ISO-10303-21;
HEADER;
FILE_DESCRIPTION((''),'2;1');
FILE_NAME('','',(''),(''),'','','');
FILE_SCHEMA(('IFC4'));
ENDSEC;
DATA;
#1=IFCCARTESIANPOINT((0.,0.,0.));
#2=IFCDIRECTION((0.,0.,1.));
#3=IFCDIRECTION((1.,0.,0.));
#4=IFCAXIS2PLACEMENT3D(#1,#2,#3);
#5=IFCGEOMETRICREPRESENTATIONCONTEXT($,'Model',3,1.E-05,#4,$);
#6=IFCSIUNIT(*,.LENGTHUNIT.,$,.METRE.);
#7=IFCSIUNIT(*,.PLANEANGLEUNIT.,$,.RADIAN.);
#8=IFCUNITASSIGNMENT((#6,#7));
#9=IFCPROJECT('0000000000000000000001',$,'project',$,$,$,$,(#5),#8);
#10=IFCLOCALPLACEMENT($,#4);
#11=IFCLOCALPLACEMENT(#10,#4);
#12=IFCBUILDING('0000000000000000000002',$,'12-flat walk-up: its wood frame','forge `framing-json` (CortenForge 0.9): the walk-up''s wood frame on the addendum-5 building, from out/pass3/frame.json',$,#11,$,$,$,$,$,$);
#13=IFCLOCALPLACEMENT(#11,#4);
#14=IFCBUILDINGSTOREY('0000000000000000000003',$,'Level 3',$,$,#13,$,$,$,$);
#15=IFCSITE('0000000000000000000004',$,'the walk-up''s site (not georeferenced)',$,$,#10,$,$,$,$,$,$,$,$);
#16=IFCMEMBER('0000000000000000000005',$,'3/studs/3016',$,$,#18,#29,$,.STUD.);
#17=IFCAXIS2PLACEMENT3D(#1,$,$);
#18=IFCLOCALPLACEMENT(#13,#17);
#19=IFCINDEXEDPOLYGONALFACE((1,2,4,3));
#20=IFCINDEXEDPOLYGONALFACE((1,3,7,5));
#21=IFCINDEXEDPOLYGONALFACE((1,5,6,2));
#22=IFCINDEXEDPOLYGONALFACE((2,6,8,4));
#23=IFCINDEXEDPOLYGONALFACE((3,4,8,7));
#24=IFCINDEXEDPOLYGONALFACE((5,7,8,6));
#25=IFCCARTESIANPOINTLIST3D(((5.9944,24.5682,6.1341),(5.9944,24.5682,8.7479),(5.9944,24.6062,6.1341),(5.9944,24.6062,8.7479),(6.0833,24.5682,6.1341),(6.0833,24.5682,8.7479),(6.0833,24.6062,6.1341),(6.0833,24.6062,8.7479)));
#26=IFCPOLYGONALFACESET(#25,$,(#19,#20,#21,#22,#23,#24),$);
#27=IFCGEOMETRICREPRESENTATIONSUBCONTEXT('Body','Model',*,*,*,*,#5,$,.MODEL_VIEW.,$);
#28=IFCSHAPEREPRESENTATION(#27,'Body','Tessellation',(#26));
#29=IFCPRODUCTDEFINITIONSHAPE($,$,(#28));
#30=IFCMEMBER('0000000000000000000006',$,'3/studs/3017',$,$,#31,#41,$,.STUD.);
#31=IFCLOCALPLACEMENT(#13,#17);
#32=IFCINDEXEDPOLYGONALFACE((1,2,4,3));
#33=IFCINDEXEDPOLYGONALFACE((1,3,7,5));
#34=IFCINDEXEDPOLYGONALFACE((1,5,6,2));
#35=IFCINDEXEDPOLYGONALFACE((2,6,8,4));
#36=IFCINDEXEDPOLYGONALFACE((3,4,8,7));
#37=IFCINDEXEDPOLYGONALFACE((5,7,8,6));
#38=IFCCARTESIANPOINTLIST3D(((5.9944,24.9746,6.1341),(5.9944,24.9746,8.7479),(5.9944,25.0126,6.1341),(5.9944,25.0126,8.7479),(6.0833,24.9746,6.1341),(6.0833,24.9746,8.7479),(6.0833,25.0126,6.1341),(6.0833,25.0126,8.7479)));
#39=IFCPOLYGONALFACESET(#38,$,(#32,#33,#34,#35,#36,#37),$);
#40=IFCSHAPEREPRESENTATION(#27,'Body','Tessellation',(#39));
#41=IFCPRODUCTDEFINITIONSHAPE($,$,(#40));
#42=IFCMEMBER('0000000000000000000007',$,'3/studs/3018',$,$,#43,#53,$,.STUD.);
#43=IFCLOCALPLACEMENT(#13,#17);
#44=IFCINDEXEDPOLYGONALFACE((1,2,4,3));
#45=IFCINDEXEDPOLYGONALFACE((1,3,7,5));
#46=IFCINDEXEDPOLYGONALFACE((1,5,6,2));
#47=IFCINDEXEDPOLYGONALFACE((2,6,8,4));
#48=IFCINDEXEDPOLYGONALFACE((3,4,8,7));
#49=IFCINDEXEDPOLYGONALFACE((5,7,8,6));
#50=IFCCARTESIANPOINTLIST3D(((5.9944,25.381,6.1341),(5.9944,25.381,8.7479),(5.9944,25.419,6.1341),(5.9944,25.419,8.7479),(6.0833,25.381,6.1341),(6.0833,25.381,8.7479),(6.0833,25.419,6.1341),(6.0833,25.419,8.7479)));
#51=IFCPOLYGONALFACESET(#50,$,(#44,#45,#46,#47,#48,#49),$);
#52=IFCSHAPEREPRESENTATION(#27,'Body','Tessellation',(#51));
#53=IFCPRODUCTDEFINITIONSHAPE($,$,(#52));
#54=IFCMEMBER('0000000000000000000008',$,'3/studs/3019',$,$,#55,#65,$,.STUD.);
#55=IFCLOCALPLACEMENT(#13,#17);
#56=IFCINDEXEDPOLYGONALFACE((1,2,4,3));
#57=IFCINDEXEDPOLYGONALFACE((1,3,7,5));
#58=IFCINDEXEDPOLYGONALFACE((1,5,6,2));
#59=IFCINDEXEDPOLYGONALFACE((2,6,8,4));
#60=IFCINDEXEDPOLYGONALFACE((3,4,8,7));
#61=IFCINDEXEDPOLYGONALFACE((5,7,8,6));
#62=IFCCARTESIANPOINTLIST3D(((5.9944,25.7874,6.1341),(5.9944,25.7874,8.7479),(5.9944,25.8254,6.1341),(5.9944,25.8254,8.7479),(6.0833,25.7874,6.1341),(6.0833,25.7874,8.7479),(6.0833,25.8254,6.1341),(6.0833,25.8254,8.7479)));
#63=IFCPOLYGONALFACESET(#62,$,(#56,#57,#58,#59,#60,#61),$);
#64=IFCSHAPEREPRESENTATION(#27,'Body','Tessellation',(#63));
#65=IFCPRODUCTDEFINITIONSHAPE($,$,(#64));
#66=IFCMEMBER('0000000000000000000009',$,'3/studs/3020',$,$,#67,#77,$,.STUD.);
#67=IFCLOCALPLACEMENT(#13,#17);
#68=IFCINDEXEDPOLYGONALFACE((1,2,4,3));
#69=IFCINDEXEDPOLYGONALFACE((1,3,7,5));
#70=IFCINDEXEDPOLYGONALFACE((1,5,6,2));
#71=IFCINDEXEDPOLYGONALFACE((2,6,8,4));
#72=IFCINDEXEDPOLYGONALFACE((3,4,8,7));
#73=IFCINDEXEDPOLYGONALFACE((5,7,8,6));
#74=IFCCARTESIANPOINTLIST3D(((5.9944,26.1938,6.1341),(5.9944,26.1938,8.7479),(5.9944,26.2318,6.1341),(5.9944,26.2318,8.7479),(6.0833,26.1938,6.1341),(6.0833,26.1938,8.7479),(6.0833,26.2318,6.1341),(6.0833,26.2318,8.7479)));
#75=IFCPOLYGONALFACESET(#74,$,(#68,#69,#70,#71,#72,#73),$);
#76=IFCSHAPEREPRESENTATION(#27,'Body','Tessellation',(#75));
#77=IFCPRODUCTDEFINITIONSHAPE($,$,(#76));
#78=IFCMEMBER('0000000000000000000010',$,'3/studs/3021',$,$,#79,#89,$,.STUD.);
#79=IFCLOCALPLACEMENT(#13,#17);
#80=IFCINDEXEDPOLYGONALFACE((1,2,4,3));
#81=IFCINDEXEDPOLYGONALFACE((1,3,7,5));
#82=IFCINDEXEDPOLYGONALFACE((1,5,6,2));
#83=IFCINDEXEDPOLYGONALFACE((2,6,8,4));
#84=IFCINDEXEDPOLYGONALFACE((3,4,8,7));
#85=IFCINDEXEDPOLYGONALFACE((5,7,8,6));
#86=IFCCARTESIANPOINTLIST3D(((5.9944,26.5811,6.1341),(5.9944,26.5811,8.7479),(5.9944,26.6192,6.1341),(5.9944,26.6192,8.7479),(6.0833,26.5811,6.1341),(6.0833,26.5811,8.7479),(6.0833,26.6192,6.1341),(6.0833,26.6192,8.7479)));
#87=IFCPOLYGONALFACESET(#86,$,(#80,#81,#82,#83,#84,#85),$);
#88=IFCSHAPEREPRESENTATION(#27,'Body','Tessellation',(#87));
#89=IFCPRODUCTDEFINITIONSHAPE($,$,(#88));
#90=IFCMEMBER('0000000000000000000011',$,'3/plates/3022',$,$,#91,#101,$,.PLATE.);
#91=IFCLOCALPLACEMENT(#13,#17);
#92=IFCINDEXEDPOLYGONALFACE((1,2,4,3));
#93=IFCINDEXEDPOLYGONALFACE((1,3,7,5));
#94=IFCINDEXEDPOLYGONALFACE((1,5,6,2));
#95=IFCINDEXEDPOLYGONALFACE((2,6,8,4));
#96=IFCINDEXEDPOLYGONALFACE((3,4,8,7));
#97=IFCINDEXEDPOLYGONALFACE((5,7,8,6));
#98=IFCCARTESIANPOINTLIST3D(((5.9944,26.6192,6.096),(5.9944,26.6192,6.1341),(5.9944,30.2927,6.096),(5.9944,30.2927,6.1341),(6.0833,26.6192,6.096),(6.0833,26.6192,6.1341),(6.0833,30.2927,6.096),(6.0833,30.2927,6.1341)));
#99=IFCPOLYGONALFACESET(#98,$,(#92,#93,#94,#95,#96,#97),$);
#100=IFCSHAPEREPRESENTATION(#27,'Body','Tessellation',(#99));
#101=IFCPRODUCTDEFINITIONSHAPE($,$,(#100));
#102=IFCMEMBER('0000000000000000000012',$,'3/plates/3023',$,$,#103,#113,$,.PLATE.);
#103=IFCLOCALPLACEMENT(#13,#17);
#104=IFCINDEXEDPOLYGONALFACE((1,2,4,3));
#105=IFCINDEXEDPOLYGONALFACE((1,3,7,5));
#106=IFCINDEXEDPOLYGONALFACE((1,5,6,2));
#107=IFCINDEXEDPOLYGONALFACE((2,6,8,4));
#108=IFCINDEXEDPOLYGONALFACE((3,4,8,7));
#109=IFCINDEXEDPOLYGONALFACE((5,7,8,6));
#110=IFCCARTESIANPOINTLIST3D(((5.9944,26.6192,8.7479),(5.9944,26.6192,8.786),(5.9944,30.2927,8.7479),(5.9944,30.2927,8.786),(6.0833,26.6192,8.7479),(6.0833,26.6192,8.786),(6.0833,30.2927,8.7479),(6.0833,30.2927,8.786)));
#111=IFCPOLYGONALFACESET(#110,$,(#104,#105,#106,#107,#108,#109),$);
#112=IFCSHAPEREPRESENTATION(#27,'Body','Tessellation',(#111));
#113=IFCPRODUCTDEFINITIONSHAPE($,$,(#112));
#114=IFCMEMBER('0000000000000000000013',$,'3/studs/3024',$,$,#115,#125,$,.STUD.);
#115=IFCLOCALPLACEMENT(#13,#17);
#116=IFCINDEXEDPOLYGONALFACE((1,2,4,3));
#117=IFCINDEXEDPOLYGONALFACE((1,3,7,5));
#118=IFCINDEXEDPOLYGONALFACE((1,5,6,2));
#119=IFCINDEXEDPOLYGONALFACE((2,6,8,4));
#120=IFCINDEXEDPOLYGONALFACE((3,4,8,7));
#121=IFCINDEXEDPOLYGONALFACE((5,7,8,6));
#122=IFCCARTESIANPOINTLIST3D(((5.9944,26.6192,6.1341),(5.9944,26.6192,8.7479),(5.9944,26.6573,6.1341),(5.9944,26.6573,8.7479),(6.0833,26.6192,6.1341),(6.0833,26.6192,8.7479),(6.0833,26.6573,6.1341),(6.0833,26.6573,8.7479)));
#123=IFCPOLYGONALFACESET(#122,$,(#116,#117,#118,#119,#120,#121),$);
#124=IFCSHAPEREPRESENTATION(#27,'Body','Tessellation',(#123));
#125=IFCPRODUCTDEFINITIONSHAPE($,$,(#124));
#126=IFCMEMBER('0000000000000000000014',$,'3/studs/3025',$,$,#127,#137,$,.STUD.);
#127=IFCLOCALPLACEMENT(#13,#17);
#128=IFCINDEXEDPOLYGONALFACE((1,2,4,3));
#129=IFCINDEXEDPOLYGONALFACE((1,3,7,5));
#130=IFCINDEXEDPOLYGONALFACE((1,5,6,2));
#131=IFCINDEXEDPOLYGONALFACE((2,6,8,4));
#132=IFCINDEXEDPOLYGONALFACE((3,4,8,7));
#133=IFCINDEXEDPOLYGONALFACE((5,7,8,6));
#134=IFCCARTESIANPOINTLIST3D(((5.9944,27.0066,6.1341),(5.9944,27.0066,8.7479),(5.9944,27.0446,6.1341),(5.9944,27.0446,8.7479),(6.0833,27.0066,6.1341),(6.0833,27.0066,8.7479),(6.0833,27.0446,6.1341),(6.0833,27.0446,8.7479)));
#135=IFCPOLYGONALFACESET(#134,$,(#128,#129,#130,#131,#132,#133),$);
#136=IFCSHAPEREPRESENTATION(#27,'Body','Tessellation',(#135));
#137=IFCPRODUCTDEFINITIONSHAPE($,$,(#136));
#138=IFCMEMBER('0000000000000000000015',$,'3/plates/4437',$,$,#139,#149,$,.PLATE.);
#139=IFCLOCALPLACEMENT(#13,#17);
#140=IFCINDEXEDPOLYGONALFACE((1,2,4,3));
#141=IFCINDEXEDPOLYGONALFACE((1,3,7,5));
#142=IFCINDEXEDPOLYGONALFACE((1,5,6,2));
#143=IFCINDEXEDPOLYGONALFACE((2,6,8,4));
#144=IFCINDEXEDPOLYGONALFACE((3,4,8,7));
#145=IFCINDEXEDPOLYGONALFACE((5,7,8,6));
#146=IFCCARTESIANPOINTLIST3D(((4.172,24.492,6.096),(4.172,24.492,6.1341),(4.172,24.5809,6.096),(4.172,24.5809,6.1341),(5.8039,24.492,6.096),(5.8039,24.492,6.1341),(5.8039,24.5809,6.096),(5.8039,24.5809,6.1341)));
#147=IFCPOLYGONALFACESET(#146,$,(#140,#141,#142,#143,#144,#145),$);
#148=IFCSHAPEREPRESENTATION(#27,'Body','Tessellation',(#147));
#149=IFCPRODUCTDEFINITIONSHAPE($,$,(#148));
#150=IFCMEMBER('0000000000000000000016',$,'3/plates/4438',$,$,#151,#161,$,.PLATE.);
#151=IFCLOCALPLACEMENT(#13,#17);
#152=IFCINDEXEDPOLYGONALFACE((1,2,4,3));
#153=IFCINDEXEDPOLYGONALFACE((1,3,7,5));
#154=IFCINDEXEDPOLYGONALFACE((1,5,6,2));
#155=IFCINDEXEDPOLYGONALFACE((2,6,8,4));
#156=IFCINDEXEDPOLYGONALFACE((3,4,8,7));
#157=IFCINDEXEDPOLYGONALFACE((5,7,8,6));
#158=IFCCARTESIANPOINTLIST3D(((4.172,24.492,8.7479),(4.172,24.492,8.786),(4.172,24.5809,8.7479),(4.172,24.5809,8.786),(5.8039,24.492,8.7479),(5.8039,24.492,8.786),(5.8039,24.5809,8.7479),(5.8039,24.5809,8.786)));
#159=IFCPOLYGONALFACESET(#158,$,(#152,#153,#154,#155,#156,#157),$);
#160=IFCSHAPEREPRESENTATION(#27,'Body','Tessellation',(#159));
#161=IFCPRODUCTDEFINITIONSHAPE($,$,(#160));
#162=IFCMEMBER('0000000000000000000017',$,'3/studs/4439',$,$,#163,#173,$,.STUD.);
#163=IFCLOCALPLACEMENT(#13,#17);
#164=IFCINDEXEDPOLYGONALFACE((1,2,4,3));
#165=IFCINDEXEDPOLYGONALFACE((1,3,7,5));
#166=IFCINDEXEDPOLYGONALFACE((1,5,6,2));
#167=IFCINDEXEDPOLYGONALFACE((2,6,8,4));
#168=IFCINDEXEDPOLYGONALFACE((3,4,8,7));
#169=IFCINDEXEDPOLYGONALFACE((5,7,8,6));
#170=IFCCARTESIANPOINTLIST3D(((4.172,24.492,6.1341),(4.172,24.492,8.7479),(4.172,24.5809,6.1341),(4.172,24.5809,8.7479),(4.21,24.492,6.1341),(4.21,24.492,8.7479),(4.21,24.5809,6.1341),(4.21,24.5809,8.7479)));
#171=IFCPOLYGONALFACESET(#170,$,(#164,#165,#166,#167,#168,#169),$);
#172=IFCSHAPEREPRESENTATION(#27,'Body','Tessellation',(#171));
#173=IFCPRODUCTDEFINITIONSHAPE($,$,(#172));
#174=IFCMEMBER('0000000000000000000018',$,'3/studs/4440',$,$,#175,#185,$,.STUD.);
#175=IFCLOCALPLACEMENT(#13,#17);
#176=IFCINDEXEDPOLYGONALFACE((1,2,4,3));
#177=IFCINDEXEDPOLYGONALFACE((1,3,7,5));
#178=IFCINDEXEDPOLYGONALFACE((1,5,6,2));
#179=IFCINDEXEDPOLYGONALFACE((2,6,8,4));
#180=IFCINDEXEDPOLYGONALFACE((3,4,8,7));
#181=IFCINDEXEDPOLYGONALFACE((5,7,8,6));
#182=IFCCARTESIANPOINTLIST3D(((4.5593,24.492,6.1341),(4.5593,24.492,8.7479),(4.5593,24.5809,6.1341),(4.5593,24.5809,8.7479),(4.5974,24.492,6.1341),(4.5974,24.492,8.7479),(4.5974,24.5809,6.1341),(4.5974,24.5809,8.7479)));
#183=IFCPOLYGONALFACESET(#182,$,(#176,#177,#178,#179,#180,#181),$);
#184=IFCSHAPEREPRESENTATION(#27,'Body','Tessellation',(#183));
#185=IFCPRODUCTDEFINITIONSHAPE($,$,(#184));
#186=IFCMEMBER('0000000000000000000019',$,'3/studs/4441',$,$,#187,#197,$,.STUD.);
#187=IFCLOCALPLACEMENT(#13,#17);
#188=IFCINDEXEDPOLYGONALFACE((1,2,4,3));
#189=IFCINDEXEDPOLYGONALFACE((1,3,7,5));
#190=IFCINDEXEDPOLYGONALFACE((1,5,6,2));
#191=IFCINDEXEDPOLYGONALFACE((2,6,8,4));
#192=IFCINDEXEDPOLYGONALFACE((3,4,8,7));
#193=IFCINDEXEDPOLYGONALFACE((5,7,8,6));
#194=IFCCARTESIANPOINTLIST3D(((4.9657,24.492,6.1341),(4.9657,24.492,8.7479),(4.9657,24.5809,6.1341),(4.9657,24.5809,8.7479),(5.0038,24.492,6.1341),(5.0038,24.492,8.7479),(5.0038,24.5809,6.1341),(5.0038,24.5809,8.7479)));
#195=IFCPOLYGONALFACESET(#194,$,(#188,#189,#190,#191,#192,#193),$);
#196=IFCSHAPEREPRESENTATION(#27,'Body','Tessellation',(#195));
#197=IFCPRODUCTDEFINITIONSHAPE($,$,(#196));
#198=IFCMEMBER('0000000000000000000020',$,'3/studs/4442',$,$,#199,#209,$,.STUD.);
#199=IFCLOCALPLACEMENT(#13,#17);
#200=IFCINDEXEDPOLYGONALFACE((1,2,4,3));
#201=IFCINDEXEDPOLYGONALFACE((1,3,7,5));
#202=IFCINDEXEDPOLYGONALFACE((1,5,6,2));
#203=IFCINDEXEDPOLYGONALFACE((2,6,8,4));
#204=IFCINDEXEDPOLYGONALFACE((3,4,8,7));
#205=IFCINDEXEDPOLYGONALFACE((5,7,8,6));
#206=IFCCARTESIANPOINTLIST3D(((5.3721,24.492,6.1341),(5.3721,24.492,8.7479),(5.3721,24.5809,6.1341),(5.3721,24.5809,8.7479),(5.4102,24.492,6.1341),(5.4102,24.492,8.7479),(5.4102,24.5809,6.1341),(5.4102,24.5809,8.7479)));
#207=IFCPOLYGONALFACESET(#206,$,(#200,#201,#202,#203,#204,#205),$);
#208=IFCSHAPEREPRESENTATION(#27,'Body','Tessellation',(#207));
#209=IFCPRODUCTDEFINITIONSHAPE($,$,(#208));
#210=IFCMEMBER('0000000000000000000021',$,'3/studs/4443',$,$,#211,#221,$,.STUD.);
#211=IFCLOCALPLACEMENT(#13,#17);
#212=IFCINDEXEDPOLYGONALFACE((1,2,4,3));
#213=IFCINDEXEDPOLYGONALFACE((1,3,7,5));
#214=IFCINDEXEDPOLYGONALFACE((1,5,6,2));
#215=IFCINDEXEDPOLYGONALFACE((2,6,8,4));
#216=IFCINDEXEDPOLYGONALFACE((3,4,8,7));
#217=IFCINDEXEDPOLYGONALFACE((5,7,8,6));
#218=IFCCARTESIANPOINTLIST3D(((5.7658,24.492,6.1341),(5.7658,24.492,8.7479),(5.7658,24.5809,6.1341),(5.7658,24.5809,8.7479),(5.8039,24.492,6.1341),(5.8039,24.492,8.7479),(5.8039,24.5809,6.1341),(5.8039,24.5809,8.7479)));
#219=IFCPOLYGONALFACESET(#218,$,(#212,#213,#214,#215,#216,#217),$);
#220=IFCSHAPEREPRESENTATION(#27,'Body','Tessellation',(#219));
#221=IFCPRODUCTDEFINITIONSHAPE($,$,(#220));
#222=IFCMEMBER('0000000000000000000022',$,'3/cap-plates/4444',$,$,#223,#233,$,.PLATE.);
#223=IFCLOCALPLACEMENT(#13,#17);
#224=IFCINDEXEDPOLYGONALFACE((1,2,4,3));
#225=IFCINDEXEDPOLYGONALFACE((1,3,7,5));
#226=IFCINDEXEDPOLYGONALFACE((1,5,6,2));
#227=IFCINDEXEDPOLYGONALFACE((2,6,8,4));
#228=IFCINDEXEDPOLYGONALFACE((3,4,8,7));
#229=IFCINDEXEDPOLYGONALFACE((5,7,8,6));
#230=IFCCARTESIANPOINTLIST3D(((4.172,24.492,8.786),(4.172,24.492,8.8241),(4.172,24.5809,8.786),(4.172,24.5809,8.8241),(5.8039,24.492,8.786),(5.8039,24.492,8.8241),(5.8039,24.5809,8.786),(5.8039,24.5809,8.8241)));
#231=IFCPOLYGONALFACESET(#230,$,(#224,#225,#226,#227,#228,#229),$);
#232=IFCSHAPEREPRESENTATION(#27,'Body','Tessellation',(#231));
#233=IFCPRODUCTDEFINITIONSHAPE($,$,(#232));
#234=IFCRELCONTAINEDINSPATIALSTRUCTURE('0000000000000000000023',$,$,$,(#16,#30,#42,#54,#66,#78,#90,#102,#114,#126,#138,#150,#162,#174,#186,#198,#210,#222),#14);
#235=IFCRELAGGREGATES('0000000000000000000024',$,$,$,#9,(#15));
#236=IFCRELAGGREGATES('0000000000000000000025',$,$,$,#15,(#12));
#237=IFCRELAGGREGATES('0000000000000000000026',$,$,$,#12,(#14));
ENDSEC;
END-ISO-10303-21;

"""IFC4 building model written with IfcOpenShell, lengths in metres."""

from ifc_helpers import new_model, si_unit, frame, frame_2d, origin, origin_with_axes, place, context, subcontext, project, spatial, rectangle, extrude, element, save


model = new_model("IFC4")

# Units and contexts
model_context = context("Model", 3, precision=1e-05, world=origin_with_axes())
body_context = subcontext(model_context, "Body", "Model", "MODEL_VIEW")
ifc_project = project(units=[si_unit("LENGTHUNIT", "METRE"), si_unit("PLANEANGLEUNIT", "RADIAN")], contexts=[model_context])

# Site, building, storey
site_placement = place(None, origin_with_axes())
site = spatial("IfcSite", under=ifc_project, at=site_placement, Name="the walk-up's site (not georeferenced)")
building_placement = place(site_placement, origin_with_axes())
building = spatial("IfcBuilding", under=site, at=building_placement, Name="12-flat walk-up: its wood frame", Description="forge `framing-json` (CortenForge 0.9): the walk-up's wood frame on the addendum-5 building, from out/pass3/frame.json")
storey_placement = place(building_placement, origin_with_axes())
storey = spatial("IfcBuildingStorey", under=building, at=storey_placement, Name="Level 3")

# Members
for number, where, z_axis, x_axis, name in (
    (1, (5.9944, 24.5681, 6.1341), (0.0, 0.0, 1.0), (1.0, 0.0, 0.0), "3/studs/3016"),
    (2, (5.9944, 24.9746, 6.1341), (0.0, 0.0, 1.0), (1.0, 0.0, 0.0), "3/studs/3017"),
    (3, (5.9944, 25.3809, 6.1341), (0.0, 0.0, 1.0), (1.0, 0.0, 0.0), "3/studs/3018"),
    (4, (5.9944, 25.7873, 6.1341), (0.0, 0.0, 1.0), (1.0, 0.0, 0.0), "3/studs/3019"),
    (5, (5.9944, 26.1938, 6.1341), (0.0, 0.0, 1.0), (1.0, 0.0, 0.0), "3/studs/3020"),
    (6, (5.9944, 26.5811, 6.1341), (0.0, 0.0, 1.0), (1.0, 0.0, 0.0), "3/studs/3021"),
):
    element("IfcMember", number, at=place(storey_placement, frame(where, z_axis=z_axis, x_axis=x_axis)), inside=storey, Name=name, PredefinedType="STUD", context=body_context, shape_type="SweptSolid", body=[
        extrude(rectangle(XDim=0.0889, YDim=0.0381, at=frame_2d((0.0445, 0.0191))), origin(), (0.0, 0.0, 1.0), 2.6138),
    ])
for number, where, z_axis, x_axis, name in (
    (7, (5.9944, 26.6192, 6.096), (0.0, 0.0, 1.0), (1.0, 0.0, 0.0), "3/plates/3022"),
    (8, (5.9944, 26.6192, 8.7479), (0.0, 0.0, 1.0), (1.0, 0.0, 0.0), "3/plates/3023"),
):
    element("IfcMember", number, at=place(storey_placement, frame(where, z_axis=z_axis, x_axis=x_axis)), inside=storey, Name=name, PredefinedType="PLATE", context=body_context, shape_type="SweptSolid", body=[
        extrude(rectangle(XDim=0.0889, YDim=3.6735, at=frame_2d((0.0445, 1.8367))), origin(), (0.0, 0.0, 1.0), 0.0381),
    ])
for number, where, z_axis, x_axis, name in (
    (9, (5.9944, 26.6192, 6.1341), (0.0, 0.0, 1.0), (1.0, 0.0, 0.0), "3/studs/3024"),
    (10, (5.9944, 27.0066, 6.1341), (0.0, 0.0, 1.0), (1.0, 0.0, 0.0), "3/studs/3025"),
):
    element("IfcMember", number, at=place(storey_placement, frame(where, z_axis=z_axis, x_axis=x_axis)), inside=storey, Name=name, PredefinedType="STUD", context=body_context, shape_type="SweptSolid", body=[
        extrude(rectangle(XDim=0.0889, YDim=0.0381, at=frame_2d((0.0445, 0.0191))), origin(), (0.0, 0.0, 1.0), 2.6138),
    ])
for number, where, z_axis, x_axis, name in (
    (11, (4.1719, 24.4919, 6.096), (0.0, 0.0, 1.0), (1.0, 0.0, 0.0), "3/plates/4437"),
    (12, (4.1719, 24.4919, 8.7479), (0.0, 0.0, 1.0), (1.0, 0.0, 0.0), "3/plates/4438"),
):
    element("IfcMember", number, at=place(storey_placement, frame(where, z_axis=z_axis, x_axis=x_axis)), inside=storey, Name=name, PredefinedType="PLATE", context=body_context, shape_type="SweptSolid", body=[
        extrude(rectangle(XDim=1.6319, YDim=0.0889, at=frame_2d((0.816, 0.0445))), origin(), (0.0, 0.0, 1.0), 0.0381),
    ])
for number, where, z_axis, x_axis, name in (
    (13, (4.1719, 24.4919, 6.1341), (0.0, 0.0, 1.0), (1.0, 0.0, 0.0), "3/studs/4439"),
    (14, (4.5593, 24.4919, 6.1341), (0.0, 0.0, 1.0), (1.0, 0.0, 0.0), "3/studs/4440"),
    (15, (4.9657, 24.4919, 6.1341), (0.0, 0.0, 1.0), (1.0, 0.0, 0.0), "3/studs/4441"),
    (16, (5.3721, 24.4919, 6.1341), (0.0, 0.0, 1.0), (1.0, 0.0, 0.0), "3/studs/4442"),
    (17, (5.7658, 24.4919, 6.1341), (0.0, 0.0, 1.0), (1.0, 0.0, 0.0), "3/studs/4443"),
):
    element("IfcMember", number, at=place(storey_placement, frame(where, z_axis=z_axis, x_axis=x_axis)), inside=storey, Name=name, PredefinedType="STUD", context=body_context, shape_type="SweptSolid", body=[
        extrude(rectangle(XDim=0.0381, YDim=0.0889, at=frame_2d((0.0191, 0.0445))), origin(), (0.0, 0.0, 1.0), 2.6138),
    ])
member_placement = place(storey_placement, frame((4.1719, 24.4919, 8.786), z_axis=(0.0, 0.0, 1.0), x_axis=(1.0, 0.0, 0.0)))
element("IfcMember", 18, at=member_placement, inside=storey, Name="3/cap-plates/4444", PredefinedType="PLATE", context=body_context, shape_type="SweptSolid", body=[
    extrude(rectangle(XDim=1.6319, YDim=0.0889, at=frame_2d((0.816, 0.0445))), origin(), (0.0, 0.0, 1.0), 0.0381),
])

save(model, "model.ifc")
